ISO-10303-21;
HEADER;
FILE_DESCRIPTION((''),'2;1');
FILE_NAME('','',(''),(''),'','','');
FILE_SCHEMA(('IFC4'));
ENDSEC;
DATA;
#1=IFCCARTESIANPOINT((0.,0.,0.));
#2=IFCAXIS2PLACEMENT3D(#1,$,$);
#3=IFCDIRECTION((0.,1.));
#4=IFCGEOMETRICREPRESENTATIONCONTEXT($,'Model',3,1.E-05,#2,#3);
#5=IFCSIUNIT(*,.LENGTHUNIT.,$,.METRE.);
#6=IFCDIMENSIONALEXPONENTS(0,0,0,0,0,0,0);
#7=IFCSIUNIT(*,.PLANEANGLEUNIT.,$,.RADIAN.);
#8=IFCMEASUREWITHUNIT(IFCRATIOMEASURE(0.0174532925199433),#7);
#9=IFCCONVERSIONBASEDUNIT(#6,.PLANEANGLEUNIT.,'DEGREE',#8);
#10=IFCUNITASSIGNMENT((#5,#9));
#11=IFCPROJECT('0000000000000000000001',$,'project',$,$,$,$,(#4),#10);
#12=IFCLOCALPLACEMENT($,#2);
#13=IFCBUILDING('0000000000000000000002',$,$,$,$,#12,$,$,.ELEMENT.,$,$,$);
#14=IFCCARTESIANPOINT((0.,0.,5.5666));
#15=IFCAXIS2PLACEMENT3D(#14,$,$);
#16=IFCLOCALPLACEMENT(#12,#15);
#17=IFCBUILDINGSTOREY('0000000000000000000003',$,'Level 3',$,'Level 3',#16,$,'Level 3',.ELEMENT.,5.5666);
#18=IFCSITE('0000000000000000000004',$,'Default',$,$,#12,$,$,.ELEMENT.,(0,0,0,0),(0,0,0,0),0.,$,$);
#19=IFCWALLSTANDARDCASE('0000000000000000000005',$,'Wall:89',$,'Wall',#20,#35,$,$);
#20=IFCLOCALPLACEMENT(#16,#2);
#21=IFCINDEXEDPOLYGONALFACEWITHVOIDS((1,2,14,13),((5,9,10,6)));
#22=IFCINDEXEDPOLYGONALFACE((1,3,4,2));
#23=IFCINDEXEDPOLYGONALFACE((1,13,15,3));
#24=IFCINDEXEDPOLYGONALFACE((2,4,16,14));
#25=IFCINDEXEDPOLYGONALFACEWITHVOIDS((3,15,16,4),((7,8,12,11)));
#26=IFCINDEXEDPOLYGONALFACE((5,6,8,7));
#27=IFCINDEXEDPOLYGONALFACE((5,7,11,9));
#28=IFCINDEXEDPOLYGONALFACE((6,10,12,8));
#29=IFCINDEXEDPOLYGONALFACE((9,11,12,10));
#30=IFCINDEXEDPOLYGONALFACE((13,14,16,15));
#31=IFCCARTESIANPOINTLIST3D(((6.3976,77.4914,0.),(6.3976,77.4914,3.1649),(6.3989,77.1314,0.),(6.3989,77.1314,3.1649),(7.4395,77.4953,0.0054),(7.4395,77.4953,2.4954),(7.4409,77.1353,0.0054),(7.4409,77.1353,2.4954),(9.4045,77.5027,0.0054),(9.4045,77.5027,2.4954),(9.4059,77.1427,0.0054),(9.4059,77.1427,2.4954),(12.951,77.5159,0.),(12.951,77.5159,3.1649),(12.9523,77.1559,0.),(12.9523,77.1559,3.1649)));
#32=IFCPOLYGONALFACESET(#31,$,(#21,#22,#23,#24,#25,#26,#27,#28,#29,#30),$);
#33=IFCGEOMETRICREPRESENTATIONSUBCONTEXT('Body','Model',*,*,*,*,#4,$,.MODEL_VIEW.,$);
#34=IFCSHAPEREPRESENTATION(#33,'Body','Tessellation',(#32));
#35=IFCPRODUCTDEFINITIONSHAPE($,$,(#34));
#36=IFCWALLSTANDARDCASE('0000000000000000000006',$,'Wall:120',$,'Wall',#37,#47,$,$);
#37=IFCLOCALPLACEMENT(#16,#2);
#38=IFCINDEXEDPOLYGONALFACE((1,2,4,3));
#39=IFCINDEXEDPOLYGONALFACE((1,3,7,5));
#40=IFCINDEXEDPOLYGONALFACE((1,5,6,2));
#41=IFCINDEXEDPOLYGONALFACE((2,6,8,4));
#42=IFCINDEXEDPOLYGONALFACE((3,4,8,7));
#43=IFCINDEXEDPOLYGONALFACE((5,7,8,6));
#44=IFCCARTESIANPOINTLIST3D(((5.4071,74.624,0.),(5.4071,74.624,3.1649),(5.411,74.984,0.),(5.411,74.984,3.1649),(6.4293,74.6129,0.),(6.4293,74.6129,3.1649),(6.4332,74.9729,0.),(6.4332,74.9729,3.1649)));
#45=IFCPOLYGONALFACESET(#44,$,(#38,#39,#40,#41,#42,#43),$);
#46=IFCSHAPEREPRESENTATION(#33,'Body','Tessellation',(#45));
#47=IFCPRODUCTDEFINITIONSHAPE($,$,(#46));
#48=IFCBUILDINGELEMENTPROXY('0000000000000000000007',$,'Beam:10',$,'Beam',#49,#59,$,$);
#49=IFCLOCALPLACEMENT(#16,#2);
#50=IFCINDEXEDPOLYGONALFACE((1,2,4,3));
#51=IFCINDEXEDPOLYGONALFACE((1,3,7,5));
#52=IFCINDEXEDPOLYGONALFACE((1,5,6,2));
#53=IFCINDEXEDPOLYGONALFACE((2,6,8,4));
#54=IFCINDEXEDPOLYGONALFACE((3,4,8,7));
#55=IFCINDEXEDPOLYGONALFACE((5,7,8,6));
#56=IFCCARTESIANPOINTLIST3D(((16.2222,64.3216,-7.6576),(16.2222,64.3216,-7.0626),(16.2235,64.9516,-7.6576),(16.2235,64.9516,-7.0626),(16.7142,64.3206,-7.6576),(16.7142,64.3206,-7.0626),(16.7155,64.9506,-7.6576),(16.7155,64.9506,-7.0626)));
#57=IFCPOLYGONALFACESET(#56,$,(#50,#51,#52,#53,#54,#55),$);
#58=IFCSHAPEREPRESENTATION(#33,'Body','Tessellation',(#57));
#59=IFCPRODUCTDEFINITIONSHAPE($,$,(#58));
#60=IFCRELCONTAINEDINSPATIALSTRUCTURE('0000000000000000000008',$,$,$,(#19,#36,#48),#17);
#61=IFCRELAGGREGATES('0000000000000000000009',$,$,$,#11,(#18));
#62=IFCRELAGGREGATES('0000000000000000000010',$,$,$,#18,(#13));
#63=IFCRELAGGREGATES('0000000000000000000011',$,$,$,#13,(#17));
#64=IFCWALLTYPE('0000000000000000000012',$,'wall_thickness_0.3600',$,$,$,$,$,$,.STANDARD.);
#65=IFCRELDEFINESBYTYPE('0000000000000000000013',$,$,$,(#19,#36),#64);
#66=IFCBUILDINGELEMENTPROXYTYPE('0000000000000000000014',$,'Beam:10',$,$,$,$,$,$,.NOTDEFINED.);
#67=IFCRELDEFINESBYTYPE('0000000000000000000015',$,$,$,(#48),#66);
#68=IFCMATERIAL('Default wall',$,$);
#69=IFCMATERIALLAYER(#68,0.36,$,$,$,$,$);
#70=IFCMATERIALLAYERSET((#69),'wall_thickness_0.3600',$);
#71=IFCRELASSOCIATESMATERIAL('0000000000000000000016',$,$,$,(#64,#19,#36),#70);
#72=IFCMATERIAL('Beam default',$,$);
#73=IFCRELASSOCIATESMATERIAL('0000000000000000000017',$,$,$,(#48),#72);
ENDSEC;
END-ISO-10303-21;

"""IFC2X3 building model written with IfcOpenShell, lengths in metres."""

from ifc_helpers import new_model, entity, si_unit, converted_unit, direction, frame, frame_2d, origin, place, context, subcontext, project, spatial, polyline, rectangle, outline, extrude, source, transform, mapped, material, layer, layer_set, layer_usage, type_object, type_shapes, element, save


model = new_model("IFC2X3")

# Units and contexts
model_context = context("Model", 3, precision=1e-05, world=origin(), true_north=direction((0.0, 1.0)))
body_context = subcontext(model_context, "Body", "Model", "MODEL_VIEW")
ifc_project = project(units=[si_unit("LENGTHUNIT", "METRE"), converted_unit("PLANEANGLEUNIT", "DEGREE", entity("IfcRatioMeasure", 0.0174532925199433), si_unit("PLANEANGLEUNIT", "RADIAN"), dimensions=[0, 0, 0, 0, 0, 0, 0])], contexts=[model_context])

# Site, building, storey
placement_1 = place(None, origin())
site = spatial("IfcSite", under=ifc_project, at=placement_1, Name="Default", CompositionType="ELEMENT", RefLatitude=(0, 0, 0, 0), RefLongitude=(0, 0, 0, 0), RefElevation=0.0)
building = spatial("IfcBuilding", under=site, at=placement_1, CompositionType="ELEMENT")
storey_placement = place(placement_1, frame((0.0, 0.0, 5.5666)))
storey = spatial("IfcBuildingStorey", under=building, at=storey_placement, Name="Level 3", ObjectType="Level 3", LongName="Level 3", CompositionType="ELEMENT", Elevation=5.5666)

# Shared definitions
ifc_material_1 = material(Name="Default wall")

# Wall, opening
ifc_layer_1 = layer(ifc_material_1, 0.36)
ifc_layer_set_1 = layer_set([ifc_layer_1], Name="wall_thickness_0.3600")
ifc_layer_usage_1 = layer_usage(ifc_layer_set_1, "AXIS2", "POSITIVE", -0.18)
wall_type_1 = type_object("IfcWallType", Name="wall_thickness_0.3600", PredefinedType="STANDARD", material=ifc_layer_set_1)
wall_1_placement = place(storey_placement, frame((6.3982, 77.3114, 0.0), z_axis=(0.0, 0.0, 1.0), x_axis=(0.999993, 0.003737, 0.0)))
wall_1 = element("IfcWallStandardCase", 1, at=wall_1_placement, inside=storey, type_object=wall_type_1, material=ifc_layer_usage_1, Name="Wall:89", ObjectType="Wall", context=body_context, shape_type="SweptSolid", body=[
    extrude(outline(polyline([(6.5535, -0.18), (6.5535, 0.18), (0.0, 0.18), (0.0, -0.18), (6.5535, -0.18)])), origin(), (0.0, 0.0, 1.0), 3.1649),
])
opening_1_placement = place(wall_1_placement, frame((1.042, -0.18, 0.0054)))
element("IfcOpeningElement", 2, at=opening_1_placement, cuts=wall_1, ObjectType="Opening", context=body_context, shape_type="SweptSolid", body=[
    extrude(rectangle(XDim=1.965, YDim=2.49, at=frame_2d((1.245, 0.9825), x_axis=(0.0, 1.0))), frame((0.0, 0.0, 0.0), z_axis=(0.0, 1.0, 0.0), x_axis=(0.0, 0.0, 1.0)), (0.0, 0.0, 1.0), 0.36),
])

# Wall
wall_2_placement = place(storey_placement, frame((5.409, 74.804, 0.0), z_axis=(0.0, 0.0, 1.0), x_axis=(0.999941, -0.010873, 0.0)))
element("IfcWallStandardCase", 3, at=wall_2_placement, inside=storey, type_object=wall_type_1, material=ifc_layer_usage_1, Name="Wall:120", ObjectType="Wall", context=body_context, shape_type="SweptSolid", body=[
    extrude(outline(polyline([(1.0223, -0.18), (1.0223, 0.18), (0.0, 0.18), (0.0, -0.18), (1.0223, -0.18)])), origin(), (0.0, 0.0, 1.0), 3.1649),
])

# Building element proxy
ifc_material_2 = material(Name="Beam default")
building_element_proxy_type = type_object("IfcBuildingElementProxyType", Name="Beam:10", PredefinedType="NOTDEFINED")
shared_shape_1 = source(origin(), body_context, "Body", "SweptSolid", [
    extrude(outline(polyline([(0.63, -0.246), (0.63, 0.246), (0.0, 0.246), (0.0, -0.246), (0.63, -0.246)])), origin(), (0.0, 0.0, 1.0), 0.595),
])
type_shapes(building_element_proxy_type, [shared_shape_1])
placement_2 = place(placement_1, frame((0.0, 0.0, -2.091)))
proxy_placement = place(placement_2, frame((16.4695, 64.9511, 0.0), z_axis=(0.0, 0.0, 1.0), x_axis=(-0.002044, -0.999998, 0.0)))
element("IfcBuildingElementProxy", 4, at=proxy_placement, inside=storey, type_object=building_element_proxy_type, material=ifc_material_2, Name="Beam:10", ObjectType="Beam", context=body_context, shape_type="MappedRepresentation", body=[
    mapped(shared_shape_1, transform((0.0, 0.0, 0.0), scale=1.0)),
])

save(model, "model.ifc")
